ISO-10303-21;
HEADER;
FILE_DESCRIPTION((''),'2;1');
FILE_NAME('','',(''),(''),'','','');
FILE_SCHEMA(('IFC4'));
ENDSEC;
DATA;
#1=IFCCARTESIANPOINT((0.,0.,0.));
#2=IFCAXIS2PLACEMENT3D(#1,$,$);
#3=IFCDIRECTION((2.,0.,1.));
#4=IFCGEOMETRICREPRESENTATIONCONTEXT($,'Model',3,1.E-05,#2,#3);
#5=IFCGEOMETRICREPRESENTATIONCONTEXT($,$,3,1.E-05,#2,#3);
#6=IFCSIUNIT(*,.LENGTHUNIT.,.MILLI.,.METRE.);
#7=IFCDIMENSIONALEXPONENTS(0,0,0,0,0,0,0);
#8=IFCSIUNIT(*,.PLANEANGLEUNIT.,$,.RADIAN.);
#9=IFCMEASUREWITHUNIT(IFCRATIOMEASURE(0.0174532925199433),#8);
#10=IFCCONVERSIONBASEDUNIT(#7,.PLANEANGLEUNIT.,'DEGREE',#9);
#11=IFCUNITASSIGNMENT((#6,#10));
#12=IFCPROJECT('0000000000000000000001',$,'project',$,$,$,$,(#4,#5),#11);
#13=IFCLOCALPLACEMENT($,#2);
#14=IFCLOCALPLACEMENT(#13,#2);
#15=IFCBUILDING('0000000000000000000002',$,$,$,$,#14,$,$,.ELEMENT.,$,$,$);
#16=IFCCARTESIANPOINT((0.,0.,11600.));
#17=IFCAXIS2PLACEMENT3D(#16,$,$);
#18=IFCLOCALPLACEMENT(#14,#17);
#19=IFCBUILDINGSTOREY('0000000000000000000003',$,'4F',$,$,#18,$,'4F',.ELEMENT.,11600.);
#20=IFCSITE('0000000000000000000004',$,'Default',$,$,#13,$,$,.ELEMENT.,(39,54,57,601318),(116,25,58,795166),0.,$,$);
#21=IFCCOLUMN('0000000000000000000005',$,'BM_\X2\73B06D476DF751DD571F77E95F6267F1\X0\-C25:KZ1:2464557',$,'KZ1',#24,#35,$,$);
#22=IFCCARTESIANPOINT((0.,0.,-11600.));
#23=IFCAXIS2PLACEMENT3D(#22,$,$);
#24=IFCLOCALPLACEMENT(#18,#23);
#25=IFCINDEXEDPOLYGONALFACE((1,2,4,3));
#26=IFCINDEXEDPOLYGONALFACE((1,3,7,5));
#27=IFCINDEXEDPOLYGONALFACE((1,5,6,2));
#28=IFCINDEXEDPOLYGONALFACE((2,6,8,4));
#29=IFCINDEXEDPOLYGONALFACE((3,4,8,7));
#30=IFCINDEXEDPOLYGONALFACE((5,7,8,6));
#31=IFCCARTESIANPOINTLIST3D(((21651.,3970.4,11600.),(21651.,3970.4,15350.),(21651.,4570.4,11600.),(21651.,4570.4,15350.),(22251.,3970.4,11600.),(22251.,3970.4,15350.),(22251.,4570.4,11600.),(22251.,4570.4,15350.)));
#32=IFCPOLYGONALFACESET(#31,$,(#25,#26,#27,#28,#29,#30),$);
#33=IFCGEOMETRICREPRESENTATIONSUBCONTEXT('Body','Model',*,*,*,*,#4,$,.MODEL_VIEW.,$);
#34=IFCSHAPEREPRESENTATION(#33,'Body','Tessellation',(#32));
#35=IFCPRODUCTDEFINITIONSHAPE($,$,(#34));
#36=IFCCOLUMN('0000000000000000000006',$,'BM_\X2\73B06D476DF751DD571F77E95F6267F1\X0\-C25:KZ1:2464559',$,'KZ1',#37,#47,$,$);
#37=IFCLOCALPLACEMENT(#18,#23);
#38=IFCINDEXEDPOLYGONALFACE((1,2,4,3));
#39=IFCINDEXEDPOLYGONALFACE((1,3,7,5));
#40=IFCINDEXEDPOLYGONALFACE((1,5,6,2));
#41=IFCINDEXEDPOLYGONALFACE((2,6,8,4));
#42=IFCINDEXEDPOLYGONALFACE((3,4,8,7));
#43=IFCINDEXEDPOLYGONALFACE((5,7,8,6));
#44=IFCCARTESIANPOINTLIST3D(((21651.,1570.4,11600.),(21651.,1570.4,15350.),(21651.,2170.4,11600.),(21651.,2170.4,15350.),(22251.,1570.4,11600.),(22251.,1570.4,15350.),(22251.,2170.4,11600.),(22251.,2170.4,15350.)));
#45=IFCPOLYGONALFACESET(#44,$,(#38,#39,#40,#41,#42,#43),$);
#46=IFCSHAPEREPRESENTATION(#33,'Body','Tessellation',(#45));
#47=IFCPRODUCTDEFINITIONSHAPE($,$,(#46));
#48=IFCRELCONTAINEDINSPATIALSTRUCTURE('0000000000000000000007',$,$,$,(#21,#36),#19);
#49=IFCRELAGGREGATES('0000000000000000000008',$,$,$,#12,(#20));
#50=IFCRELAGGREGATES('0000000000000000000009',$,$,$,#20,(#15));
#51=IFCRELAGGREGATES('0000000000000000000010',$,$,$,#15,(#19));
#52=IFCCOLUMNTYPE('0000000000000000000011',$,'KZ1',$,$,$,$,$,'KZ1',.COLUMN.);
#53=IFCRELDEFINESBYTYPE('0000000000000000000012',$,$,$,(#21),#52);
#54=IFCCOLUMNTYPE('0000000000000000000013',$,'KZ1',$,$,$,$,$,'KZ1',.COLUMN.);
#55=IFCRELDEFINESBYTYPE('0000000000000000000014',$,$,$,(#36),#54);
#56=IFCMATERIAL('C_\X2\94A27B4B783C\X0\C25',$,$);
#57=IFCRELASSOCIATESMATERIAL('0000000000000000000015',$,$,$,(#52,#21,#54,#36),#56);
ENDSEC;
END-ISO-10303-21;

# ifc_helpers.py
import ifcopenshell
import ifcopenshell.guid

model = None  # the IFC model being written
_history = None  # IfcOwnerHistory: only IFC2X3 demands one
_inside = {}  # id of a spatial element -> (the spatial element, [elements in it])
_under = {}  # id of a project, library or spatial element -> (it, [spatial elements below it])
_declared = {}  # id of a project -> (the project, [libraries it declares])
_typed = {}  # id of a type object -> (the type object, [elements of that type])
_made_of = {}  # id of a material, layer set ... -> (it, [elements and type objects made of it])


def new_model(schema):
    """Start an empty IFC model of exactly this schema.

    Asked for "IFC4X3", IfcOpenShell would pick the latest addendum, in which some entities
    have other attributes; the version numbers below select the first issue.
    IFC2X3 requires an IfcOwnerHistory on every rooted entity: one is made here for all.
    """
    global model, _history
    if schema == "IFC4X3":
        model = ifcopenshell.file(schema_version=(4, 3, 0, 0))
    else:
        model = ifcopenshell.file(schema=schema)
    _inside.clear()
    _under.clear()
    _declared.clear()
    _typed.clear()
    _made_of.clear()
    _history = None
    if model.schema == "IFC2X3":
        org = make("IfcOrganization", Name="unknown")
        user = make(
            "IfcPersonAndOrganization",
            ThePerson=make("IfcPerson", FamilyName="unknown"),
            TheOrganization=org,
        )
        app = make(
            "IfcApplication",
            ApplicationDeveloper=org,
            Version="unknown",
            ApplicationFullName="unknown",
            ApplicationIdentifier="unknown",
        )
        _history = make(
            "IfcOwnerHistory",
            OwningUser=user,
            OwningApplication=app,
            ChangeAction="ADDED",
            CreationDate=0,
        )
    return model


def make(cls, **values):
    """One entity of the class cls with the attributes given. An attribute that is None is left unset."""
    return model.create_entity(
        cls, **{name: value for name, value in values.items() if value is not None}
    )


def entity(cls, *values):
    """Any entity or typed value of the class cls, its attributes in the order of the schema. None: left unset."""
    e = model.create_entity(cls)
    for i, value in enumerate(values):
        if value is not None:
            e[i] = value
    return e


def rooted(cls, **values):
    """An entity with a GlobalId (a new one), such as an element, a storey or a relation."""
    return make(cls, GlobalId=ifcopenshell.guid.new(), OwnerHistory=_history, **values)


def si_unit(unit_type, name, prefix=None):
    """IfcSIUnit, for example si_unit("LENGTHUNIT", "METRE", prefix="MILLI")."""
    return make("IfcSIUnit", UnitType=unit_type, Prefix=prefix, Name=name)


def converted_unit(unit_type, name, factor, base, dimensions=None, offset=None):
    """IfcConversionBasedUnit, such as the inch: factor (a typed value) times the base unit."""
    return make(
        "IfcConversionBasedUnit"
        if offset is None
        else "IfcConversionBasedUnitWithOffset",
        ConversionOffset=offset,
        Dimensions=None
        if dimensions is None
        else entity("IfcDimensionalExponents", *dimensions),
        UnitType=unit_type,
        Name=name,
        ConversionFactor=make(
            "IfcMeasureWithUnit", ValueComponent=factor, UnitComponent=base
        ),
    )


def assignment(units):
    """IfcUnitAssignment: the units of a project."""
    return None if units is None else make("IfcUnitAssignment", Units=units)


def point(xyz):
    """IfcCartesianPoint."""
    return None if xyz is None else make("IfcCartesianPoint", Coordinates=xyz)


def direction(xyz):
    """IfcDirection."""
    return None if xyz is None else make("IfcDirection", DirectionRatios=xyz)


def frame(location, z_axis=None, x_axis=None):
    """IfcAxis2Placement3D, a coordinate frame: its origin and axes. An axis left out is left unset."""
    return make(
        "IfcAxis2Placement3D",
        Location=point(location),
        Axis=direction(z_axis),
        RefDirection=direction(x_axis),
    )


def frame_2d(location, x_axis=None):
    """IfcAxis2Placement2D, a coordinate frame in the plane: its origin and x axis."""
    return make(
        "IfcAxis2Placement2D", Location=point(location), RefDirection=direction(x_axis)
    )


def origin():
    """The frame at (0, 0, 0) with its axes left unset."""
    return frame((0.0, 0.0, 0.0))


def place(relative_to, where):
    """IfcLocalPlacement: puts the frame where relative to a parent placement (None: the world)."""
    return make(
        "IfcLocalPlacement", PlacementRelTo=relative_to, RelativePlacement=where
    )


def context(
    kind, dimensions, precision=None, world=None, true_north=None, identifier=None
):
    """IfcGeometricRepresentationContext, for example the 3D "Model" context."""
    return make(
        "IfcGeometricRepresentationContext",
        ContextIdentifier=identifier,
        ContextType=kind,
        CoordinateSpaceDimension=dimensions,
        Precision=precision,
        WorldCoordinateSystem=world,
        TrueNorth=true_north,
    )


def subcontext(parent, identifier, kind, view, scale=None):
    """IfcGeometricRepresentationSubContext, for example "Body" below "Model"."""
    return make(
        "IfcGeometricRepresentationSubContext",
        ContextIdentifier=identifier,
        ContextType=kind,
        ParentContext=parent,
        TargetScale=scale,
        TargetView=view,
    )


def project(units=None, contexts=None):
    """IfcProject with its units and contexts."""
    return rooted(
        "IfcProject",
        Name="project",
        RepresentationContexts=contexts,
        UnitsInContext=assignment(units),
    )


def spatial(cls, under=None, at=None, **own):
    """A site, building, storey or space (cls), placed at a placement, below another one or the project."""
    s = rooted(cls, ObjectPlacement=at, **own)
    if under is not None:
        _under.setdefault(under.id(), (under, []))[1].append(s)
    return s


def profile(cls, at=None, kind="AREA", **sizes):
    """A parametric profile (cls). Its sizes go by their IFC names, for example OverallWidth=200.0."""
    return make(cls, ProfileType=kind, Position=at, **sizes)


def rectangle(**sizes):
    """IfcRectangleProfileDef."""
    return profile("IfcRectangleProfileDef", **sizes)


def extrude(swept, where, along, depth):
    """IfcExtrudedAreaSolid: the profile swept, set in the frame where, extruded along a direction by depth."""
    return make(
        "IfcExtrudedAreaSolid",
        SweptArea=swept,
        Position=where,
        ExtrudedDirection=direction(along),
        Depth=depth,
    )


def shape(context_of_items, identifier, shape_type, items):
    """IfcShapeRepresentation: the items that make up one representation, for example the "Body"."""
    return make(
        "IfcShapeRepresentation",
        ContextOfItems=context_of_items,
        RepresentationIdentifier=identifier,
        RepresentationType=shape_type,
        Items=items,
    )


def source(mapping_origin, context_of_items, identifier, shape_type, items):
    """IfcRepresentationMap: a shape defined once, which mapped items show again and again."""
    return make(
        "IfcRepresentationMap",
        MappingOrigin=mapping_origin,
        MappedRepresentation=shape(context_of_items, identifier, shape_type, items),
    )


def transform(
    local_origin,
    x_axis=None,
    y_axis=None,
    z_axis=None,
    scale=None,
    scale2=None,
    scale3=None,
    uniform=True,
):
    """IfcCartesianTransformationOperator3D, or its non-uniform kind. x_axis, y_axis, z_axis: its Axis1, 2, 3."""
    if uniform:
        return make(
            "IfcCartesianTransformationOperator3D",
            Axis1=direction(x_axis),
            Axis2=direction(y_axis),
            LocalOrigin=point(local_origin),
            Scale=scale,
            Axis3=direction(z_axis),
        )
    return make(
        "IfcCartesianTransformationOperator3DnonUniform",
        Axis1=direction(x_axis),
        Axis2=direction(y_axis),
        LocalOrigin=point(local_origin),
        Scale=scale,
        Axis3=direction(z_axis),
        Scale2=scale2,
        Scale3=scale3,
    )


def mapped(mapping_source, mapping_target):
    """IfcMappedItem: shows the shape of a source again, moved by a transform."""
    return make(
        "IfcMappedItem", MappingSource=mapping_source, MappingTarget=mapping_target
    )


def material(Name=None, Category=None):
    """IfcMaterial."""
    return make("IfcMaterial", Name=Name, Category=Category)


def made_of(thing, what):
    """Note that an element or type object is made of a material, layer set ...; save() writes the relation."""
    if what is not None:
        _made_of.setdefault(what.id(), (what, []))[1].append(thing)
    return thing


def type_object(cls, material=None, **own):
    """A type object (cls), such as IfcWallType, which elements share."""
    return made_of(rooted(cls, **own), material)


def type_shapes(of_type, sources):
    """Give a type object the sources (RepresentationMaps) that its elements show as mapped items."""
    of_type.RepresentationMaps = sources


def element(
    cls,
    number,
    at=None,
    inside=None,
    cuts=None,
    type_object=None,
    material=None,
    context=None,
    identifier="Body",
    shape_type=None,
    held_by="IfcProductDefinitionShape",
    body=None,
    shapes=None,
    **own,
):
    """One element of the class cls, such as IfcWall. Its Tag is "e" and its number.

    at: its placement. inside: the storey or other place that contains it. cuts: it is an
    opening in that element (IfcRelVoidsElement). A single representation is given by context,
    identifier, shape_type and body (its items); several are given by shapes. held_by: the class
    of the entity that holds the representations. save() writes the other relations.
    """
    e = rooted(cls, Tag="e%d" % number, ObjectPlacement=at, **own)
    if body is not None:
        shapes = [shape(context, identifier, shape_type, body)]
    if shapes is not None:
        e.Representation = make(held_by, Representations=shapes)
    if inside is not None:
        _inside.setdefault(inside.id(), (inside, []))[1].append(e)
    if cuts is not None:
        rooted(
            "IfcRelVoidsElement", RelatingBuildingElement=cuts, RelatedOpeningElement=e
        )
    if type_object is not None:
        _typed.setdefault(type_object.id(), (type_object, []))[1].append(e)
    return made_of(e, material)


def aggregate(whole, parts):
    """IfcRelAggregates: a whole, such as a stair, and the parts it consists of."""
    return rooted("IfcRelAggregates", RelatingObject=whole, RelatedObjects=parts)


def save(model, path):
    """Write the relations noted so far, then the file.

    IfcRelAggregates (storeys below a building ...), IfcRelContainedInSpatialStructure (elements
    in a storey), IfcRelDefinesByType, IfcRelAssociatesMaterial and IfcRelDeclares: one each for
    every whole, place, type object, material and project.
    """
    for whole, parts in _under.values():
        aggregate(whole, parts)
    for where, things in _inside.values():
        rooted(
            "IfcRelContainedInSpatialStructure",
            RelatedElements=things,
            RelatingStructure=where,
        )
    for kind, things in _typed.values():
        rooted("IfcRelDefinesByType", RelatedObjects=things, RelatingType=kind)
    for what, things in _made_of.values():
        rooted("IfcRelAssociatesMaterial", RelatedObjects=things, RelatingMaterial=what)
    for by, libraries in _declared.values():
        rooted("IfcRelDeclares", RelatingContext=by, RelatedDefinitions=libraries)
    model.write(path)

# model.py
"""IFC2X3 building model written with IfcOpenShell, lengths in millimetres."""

from ifc_helpers import new_model, entity, si_unit, converted_unit, direction, frame, frame_2d, origin, place, context, subcontext, project, spatial, rectangle, extrude, source, transform, mapped, material, type_object, type_shapes, element, save


model = new_model("IFC2X3")

# Units and contexts
model_context = context("Model", 3, precision=1e-05, world=origin(), true_north=direction((2.0, 0.0, 1.0)))
context_of_model = context(None, 3, precision=1e-05, world=origin(), true_north=direction((2.0, 0.0, 1.0)))
body_context = subcontext(model_context, "Body", "Model", "MODEL_VIEW")
ifc_project = project(units=[si_unit("LENGTHUNIT", "METRE", prefix="MILLI"), converted_unit("PLANEANGLEUNIT", "DEGREE", entity("IfcRatioMeasure", 0.0174532925199433), si_unit("PLANEANGLEUNIT", "RADIAN"), dimensions=[0, 0, 0, 0, 0, 0, 0])], contexts=[model_context, context_of_model])

# Site, building, storey
site_placement = place(None, origin())
site = spatial("IfcSite", under=ifc_project, at=site_placement, Name="Default", CompositionType="ELEMENT", RefLatitude=(39, 54, 57, 601318), RefLongitude=(116, 25, 58, 795166), RefElevation=0.0)
building_placement = place(site_placement, origin())
building = spatial("IfcBuilding", under=site, at=building_placement, CompositionType="ELEMENT")
storey_placement = place(building_placement, frame((0.0, 0.0, 11600.0)))
storey = spatial("IfcBuildingStorey", under=building, at=storey_placement, Name="4F", LongName="4F", CompositionType="ELEMENT", Elevation=11600.0)

# Columns
ifc_material = material(Name="C_钢筋砼C25")
column_type_1 = type_object("IfcColumnType", Name="KZ1", ElementType="KZ1", PredefinedType="COLUMN", material=ifc_material)
shared_shape_1 = source(origin(), body_context, "Body", "SweptSolid", [
    extrude(rectangle(XDim=600.0, YDim=600.0, at=frame_2d((0.0, 0.0), x_axis=(1.0, 0.0))), frame((21951.0, 4270.4, 11600.0), z_axis=(0.0, 0.0, 1.0), x_axis=(-1.0, 0.0, 0.0)), (0.0, 0.0, 1.0), 3750.0),
])
type_shapes(column_type_1, [shared_shape_1])
column_1_placement = place(storey_placement, frame((0.0, 0.0, -11600.0)))
element("IfcColumn", 1, at=column_1_placement, inside=storey, type_object=column_type_1, material=ifc_material, Name="BM_现浇混凝土矩形柱-C25:KZ1:2464557", ObjectType="KZ1", context=body_context, shape_type="MappedRepresentation", body=[
    mapped(shared_shape_1, transform((0.0, 0.0, 0.0), scale=1.0)),
])
column_type_2 = type_object("IfcColumnType", Name="KZ1", ElementType="KZ1", PredefinedType="COLUMN", material=ifc_material)
shared_shape_2 = source(origin(), body_context, "Body", "SweptSolid", [
    extrude(rectangle(XDim=600.0, YDim=600.0, at=frame_2d((0.0, 0.0), x_axis=(1.0, 0.0))), frame((21951.0, 1870.4, 11600.0), z_axis=(0.0, 0.0, 1.0), x_axis=(-1.0, 0.0, 0.0)), (0.0, 0.0, 1.0), 3750.0),
])
type_shapes(column_type_2, [shared_shape_2])
column_2_placement = place(storey_placement, frame((0.0, 0.0, -11600.0)))
element("IfcColumn", 2, at=column_2_placement, inside=storey, type_object=column_type_2, material=ifc_material, Name="BM_现浇混凝土矩形柱-C25:KZ1:2464559", ObjectType="KZ1", context=body_context, shape_type="MappedRepresentation", body=[
    mapped(shared_shape_2, transform((0.0, 0.0, 0.0), scale=1.0)),
])

save(model, "model.ifc")
